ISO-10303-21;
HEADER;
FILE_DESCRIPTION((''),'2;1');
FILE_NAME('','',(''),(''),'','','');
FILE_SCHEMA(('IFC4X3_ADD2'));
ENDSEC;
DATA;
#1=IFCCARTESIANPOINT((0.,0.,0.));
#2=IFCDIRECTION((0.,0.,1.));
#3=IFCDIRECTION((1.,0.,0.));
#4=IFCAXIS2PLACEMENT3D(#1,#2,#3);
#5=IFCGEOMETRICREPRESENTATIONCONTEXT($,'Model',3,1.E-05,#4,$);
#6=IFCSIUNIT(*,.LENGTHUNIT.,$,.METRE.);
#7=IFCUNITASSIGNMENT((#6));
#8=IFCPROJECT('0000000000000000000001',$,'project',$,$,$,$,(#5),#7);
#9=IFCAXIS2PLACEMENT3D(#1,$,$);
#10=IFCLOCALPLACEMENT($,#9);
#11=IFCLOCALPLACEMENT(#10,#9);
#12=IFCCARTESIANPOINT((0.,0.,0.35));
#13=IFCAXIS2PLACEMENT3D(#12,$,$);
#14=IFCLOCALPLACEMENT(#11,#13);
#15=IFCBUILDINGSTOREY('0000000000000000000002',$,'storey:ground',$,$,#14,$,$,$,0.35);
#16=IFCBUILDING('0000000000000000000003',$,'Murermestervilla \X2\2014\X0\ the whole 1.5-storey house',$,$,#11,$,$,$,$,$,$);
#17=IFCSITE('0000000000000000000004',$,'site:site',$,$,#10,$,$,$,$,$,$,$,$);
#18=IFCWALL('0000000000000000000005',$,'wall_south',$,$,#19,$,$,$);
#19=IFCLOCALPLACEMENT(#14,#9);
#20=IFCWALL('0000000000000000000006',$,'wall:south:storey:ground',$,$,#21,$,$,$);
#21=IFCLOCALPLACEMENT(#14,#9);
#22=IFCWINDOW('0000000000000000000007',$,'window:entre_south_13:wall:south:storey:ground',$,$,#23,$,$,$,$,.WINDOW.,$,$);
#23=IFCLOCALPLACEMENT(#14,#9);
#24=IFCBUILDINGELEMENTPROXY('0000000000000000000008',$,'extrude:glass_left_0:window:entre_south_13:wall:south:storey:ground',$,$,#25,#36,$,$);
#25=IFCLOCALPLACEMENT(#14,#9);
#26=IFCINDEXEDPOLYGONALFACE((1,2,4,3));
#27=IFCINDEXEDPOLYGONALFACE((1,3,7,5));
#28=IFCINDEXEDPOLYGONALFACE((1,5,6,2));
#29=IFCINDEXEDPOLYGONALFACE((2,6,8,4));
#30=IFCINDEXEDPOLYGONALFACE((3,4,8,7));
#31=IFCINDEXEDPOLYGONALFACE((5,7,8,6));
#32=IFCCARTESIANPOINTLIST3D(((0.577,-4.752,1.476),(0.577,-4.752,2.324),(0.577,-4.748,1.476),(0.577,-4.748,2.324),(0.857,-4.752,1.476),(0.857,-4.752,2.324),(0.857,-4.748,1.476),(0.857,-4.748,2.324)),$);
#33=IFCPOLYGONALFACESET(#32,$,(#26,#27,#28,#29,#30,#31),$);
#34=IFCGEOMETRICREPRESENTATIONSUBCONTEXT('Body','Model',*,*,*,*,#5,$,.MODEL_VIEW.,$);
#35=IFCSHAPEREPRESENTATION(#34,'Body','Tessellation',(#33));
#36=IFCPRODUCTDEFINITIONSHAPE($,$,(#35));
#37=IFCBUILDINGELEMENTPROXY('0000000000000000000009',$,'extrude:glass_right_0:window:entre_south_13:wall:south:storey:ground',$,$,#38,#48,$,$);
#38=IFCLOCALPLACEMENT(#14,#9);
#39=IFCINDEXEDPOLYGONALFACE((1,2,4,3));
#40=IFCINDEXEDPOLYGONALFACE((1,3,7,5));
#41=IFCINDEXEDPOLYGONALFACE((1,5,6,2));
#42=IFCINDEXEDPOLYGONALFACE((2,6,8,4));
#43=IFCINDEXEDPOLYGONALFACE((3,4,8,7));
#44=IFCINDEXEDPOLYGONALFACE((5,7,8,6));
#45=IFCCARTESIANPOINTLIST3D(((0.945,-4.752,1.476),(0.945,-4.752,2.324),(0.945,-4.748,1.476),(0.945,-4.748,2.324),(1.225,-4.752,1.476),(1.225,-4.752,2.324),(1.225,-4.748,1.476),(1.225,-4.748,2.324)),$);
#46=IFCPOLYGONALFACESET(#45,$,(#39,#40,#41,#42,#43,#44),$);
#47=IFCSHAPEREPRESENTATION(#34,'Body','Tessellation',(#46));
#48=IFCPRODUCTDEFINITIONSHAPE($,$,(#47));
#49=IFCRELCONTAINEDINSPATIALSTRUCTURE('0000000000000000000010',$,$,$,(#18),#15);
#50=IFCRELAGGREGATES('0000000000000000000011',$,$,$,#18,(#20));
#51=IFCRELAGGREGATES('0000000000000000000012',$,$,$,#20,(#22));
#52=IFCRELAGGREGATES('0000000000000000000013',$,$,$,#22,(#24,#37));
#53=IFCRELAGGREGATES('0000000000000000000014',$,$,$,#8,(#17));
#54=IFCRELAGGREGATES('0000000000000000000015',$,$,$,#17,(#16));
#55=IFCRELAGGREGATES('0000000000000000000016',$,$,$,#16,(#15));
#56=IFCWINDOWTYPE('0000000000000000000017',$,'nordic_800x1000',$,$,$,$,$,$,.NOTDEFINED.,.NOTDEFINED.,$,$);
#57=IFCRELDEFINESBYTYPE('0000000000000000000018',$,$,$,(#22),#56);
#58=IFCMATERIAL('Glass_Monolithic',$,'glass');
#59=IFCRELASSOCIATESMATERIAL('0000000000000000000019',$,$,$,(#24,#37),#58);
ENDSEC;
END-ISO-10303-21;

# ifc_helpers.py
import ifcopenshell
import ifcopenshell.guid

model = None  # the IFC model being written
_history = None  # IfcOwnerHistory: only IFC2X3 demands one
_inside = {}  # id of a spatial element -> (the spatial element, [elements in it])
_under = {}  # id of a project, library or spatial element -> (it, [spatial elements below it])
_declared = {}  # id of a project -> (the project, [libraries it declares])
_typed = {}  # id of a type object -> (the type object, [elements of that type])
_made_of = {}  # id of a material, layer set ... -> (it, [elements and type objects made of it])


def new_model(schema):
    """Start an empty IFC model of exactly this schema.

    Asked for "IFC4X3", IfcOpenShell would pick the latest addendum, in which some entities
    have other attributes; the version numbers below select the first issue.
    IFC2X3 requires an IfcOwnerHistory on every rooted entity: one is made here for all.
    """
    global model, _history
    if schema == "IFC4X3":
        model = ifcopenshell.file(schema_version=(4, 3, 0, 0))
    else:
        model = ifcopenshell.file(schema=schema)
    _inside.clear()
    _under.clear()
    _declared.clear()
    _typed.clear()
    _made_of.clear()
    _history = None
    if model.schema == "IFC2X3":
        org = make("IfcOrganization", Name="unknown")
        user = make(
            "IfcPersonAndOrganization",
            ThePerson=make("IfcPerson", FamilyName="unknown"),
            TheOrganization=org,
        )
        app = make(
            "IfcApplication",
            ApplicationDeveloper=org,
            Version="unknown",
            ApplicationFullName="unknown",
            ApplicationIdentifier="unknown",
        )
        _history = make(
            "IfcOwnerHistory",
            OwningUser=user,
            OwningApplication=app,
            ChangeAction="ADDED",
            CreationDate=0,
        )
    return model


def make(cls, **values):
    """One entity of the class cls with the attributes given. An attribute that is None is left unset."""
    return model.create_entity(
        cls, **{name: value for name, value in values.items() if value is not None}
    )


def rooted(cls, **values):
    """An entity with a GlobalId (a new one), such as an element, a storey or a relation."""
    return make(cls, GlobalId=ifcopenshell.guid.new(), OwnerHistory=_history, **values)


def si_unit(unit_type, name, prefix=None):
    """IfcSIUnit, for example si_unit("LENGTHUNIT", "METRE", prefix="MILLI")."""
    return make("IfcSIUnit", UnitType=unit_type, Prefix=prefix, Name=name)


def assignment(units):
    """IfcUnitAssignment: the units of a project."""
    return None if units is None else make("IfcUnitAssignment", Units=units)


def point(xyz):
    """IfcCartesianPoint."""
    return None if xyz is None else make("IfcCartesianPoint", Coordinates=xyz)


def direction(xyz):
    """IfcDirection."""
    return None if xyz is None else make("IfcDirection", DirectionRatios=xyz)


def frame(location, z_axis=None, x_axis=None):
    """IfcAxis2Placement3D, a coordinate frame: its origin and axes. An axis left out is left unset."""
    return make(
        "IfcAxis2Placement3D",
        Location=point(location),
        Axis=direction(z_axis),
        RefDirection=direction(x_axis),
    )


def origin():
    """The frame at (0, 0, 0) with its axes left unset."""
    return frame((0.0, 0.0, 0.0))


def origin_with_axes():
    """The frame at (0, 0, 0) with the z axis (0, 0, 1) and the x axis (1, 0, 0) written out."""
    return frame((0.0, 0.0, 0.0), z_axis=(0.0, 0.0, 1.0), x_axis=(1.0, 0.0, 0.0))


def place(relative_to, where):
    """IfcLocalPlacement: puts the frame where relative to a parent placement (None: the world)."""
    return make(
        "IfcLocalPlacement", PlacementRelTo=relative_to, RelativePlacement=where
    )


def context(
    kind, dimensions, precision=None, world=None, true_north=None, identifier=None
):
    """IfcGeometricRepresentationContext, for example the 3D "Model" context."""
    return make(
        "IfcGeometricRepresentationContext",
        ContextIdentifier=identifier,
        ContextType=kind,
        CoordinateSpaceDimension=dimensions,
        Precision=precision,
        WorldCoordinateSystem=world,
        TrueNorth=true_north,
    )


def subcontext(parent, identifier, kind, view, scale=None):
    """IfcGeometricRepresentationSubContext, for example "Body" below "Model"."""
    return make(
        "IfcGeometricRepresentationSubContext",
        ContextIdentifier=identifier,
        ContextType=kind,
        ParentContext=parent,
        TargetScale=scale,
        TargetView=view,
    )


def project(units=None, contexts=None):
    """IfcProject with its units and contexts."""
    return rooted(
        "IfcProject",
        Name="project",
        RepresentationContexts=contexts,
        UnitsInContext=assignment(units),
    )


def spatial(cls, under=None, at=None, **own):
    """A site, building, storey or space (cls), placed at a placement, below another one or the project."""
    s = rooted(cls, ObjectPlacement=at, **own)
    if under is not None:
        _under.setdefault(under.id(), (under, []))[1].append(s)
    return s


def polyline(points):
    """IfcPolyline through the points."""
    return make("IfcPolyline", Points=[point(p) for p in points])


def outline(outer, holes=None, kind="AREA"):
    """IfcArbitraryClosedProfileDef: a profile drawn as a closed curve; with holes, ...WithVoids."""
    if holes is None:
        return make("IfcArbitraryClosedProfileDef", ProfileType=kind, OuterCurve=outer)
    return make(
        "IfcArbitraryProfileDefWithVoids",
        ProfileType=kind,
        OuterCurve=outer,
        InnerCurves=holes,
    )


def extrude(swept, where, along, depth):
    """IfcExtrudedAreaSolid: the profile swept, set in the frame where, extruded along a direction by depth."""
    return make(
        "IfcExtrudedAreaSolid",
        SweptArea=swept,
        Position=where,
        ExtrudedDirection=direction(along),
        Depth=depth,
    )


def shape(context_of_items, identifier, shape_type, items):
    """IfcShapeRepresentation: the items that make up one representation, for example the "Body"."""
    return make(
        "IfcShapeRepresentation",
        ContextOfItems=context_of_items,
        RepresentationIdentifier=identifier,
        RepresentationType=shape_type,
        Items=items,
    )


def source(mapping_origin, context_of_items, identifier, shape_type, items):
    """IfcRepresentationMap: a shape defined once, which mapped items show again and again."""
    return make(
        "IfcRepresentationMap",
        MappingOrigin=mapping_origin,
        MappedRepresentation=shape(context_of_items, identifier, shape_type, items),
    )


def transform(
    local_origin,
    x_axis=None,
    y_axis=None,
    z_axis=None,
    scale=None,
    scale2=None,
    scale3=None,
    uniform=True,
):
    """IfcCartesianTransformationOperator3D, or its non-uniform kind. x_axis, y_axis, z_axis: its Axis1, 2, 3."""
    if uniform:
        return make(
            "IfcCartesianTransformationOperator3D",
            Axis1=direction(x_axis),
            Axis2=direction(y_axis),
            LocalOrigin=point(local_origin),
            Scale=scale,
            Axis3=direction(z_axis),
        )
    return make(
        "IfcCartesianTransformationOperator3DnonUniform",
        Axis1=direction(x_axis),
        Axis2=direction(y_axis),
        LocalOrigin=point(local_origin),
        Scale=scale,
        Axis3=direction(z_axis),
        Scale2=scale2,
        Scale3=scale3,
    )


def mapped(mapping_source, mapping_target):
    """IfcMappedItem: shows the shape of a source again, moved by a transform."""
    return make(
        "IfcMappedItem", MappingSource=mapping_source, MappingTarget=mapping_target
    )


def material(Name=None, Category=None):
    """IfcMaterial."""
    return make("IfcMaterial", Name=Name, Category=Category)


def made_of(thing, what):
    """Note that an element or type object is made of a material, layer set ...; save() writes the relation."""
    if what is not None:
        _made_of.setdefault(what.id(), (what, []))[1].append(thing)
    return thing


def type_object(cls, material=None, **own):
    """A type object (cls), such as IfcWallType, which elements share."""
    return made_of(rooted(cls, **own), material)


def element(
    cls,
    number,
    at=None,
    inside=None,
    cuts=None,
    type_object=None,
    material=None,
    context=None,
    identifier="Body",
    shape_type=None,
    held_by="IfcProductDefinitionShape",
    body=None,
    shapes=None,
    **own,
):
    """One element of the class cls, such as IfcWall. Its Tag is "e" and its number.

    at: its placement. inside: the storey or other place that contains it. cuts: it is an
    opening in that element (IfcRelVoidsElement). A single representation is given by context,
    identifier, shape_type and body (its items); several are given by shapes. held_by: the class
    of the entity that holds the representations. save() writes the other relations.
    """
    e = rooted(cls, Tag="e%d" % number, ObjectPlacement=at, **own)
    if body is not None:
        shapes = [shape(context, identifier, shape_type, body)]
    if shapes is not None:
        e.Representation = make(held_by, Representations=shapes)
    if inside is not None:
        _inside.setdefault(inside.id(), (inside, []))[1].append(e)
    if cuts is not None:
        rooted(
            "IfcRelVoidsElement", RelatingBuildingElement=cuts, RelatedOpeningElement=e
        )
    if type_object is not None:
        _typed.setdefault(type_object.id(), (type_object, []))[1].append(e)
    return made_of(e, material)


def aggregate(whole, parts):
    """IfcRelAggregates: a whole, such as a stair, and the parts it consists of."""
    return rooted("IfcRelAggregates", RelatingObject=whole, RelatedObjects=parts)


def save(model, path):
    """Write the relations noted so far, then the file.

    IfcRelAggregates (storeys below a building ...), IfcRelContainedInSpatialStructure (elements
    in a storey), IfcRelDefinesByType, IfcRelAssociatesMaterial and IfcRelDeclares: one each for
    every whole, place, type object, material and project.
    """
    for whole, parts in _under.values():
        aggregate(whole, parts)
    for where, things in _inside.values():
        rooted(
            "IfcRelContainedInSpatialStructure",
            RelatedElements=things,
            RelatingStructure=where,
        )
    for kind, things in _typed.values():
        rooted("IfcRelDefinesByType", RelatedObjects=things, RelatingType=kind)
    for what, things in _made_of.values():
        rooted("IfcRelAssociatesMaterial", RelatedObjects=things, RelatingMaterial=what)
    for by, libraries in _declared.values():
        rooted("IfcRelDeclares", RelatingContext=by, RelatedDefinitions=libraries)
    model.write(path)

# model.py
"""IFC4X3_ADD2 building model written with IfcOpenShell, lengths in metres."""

from ifc_helpers import new_model, si_unit, frame, origin, origin_with_axes, place, context, subcontext, project, spatial, polyline, outline, extrude, source, transform, mapped, material, type_object, element, aggregate, save


model = new_model("IFC4X3_ADD2")

# Units and contexts
model_context = context("Model", 3, precision=1e-05, world=origin_with_axes())
body_context = subcontext(model_context, "Body", "Model", "MODEL_VIEW")
ifc_project = project(units=[si_unit("LENGTHUNIT", "METRE")], contexts=[model_context])

# Site, building, storey
site_placement = place(None, origin())
site = spatial("IfcSite", under=ifc_project, at=site_placement, Name="site:site")
building_placement = place(site_placement, origin())
building = spatial("IfcBuilding", under=site, at=building_placement, Name="Murermestervilla — the whole 1.5-storey house")
storey_placement = place(building_placement, frame((0.0, 0.0, 0.35)))
storey = spatial("IfcBuildingStorey", under=building, at=storey_placement, Name="storey:ground", Elevation=0.35)

# Walls, window, building element proxies
wall_1_placement = place(storey_placement, origin())
wall_1 = element("IfcWall", 1, at=wall_1_placement, inside=storey, Name="wall_south")
wall_2_placement = place(wall_1_placement, frame((0.0, 0.0, -0.35)))
wall_2 = element("IfcWall", 2, at=wall_2_placement, Name="wall:south:storey:ground")
aggregate(wall_1, [wall_2])
window_type_1 = type_object("IfcWindowType", Name="nordic_800x1000", PartitioningType="NOTDEFINED", PredefinedType="NOTDEFINED")
window_1_placement = place(None, frame((0.901, -4.828, 1.75)))
window_1 = element("IfcWindow", 3, at=window_1_placement, type_object=window_type_1, Name="window:entre_south_13:wall:south:storey:ground", PredefinedType="WINDOW")
aggregate(wall_2, [window_1])
ifc_material_1 = material(Name="Glass_Monolithic", Category="glass")
shared_shape_1 = source(origin(), body_context, "Body", "SweptSolid", [
    extrude(outline(polyline([(-0.14, -0.424), (0.14, -0.424), (0.14, 0.424), (-0.14, 0.424), (-0.14, -0.424)])), frame((0.0, 0.0, -0.002)), (0.0, 0.0, 1.0), 0.004),
])
proxy_1_placement = place(None, frame((0.717, -4.75, 2.25), z_axis=(0.0, -1.0, 0.0), x_axis=(1.0, 0.0, 0.0)))
proxy_1 = element("IfcBuildingElementProxy", 4, at=proxy_1_placement, material=ifc_material_1, Name="extrude:glass_left_0:window:entre_south_13:wall:south:storey:ground", context=body_context, shape_type="MappedRepresentation", body=[
    mapped(shared_shape_1, transform((0.0, 0.0, 0.0))),
])
shared_shape_2 = source(origin(), body_context, "Body", "SweptSolid", [
    extrude(outline(polyline([(-0.14, -0.424), (0.14, -0.424), (0.14, 0.424), (-0.14, 0.424), (-0.14, -0.424)])), frame((0.0, 0.0, -0.002)), (0.0, 0.0, 1.0), 0.004),
])
proxy_2_placement = place(None, frame((1.085, -4.75, 2.25), z_axis=(0.0, -1.0, 0.0), x_axis=(1.0, 0.0, 0.0)))
proxy_2 = element("IfcBuildingElementProxy", 5, at=proxy_2_placement, material=ifc_material_1, Name="extrude:glass_right_0:window:entre_south_13:wall:south:storey:ground", context=body_context, shape_type="MappedRepresentation", body=[
    mapped(shared_shape_2, transform((0.0, 0.0, 0.0))),
])
aggregate(window_1, [proxy_1, proxy_2])

save(model, "model.ifc")
